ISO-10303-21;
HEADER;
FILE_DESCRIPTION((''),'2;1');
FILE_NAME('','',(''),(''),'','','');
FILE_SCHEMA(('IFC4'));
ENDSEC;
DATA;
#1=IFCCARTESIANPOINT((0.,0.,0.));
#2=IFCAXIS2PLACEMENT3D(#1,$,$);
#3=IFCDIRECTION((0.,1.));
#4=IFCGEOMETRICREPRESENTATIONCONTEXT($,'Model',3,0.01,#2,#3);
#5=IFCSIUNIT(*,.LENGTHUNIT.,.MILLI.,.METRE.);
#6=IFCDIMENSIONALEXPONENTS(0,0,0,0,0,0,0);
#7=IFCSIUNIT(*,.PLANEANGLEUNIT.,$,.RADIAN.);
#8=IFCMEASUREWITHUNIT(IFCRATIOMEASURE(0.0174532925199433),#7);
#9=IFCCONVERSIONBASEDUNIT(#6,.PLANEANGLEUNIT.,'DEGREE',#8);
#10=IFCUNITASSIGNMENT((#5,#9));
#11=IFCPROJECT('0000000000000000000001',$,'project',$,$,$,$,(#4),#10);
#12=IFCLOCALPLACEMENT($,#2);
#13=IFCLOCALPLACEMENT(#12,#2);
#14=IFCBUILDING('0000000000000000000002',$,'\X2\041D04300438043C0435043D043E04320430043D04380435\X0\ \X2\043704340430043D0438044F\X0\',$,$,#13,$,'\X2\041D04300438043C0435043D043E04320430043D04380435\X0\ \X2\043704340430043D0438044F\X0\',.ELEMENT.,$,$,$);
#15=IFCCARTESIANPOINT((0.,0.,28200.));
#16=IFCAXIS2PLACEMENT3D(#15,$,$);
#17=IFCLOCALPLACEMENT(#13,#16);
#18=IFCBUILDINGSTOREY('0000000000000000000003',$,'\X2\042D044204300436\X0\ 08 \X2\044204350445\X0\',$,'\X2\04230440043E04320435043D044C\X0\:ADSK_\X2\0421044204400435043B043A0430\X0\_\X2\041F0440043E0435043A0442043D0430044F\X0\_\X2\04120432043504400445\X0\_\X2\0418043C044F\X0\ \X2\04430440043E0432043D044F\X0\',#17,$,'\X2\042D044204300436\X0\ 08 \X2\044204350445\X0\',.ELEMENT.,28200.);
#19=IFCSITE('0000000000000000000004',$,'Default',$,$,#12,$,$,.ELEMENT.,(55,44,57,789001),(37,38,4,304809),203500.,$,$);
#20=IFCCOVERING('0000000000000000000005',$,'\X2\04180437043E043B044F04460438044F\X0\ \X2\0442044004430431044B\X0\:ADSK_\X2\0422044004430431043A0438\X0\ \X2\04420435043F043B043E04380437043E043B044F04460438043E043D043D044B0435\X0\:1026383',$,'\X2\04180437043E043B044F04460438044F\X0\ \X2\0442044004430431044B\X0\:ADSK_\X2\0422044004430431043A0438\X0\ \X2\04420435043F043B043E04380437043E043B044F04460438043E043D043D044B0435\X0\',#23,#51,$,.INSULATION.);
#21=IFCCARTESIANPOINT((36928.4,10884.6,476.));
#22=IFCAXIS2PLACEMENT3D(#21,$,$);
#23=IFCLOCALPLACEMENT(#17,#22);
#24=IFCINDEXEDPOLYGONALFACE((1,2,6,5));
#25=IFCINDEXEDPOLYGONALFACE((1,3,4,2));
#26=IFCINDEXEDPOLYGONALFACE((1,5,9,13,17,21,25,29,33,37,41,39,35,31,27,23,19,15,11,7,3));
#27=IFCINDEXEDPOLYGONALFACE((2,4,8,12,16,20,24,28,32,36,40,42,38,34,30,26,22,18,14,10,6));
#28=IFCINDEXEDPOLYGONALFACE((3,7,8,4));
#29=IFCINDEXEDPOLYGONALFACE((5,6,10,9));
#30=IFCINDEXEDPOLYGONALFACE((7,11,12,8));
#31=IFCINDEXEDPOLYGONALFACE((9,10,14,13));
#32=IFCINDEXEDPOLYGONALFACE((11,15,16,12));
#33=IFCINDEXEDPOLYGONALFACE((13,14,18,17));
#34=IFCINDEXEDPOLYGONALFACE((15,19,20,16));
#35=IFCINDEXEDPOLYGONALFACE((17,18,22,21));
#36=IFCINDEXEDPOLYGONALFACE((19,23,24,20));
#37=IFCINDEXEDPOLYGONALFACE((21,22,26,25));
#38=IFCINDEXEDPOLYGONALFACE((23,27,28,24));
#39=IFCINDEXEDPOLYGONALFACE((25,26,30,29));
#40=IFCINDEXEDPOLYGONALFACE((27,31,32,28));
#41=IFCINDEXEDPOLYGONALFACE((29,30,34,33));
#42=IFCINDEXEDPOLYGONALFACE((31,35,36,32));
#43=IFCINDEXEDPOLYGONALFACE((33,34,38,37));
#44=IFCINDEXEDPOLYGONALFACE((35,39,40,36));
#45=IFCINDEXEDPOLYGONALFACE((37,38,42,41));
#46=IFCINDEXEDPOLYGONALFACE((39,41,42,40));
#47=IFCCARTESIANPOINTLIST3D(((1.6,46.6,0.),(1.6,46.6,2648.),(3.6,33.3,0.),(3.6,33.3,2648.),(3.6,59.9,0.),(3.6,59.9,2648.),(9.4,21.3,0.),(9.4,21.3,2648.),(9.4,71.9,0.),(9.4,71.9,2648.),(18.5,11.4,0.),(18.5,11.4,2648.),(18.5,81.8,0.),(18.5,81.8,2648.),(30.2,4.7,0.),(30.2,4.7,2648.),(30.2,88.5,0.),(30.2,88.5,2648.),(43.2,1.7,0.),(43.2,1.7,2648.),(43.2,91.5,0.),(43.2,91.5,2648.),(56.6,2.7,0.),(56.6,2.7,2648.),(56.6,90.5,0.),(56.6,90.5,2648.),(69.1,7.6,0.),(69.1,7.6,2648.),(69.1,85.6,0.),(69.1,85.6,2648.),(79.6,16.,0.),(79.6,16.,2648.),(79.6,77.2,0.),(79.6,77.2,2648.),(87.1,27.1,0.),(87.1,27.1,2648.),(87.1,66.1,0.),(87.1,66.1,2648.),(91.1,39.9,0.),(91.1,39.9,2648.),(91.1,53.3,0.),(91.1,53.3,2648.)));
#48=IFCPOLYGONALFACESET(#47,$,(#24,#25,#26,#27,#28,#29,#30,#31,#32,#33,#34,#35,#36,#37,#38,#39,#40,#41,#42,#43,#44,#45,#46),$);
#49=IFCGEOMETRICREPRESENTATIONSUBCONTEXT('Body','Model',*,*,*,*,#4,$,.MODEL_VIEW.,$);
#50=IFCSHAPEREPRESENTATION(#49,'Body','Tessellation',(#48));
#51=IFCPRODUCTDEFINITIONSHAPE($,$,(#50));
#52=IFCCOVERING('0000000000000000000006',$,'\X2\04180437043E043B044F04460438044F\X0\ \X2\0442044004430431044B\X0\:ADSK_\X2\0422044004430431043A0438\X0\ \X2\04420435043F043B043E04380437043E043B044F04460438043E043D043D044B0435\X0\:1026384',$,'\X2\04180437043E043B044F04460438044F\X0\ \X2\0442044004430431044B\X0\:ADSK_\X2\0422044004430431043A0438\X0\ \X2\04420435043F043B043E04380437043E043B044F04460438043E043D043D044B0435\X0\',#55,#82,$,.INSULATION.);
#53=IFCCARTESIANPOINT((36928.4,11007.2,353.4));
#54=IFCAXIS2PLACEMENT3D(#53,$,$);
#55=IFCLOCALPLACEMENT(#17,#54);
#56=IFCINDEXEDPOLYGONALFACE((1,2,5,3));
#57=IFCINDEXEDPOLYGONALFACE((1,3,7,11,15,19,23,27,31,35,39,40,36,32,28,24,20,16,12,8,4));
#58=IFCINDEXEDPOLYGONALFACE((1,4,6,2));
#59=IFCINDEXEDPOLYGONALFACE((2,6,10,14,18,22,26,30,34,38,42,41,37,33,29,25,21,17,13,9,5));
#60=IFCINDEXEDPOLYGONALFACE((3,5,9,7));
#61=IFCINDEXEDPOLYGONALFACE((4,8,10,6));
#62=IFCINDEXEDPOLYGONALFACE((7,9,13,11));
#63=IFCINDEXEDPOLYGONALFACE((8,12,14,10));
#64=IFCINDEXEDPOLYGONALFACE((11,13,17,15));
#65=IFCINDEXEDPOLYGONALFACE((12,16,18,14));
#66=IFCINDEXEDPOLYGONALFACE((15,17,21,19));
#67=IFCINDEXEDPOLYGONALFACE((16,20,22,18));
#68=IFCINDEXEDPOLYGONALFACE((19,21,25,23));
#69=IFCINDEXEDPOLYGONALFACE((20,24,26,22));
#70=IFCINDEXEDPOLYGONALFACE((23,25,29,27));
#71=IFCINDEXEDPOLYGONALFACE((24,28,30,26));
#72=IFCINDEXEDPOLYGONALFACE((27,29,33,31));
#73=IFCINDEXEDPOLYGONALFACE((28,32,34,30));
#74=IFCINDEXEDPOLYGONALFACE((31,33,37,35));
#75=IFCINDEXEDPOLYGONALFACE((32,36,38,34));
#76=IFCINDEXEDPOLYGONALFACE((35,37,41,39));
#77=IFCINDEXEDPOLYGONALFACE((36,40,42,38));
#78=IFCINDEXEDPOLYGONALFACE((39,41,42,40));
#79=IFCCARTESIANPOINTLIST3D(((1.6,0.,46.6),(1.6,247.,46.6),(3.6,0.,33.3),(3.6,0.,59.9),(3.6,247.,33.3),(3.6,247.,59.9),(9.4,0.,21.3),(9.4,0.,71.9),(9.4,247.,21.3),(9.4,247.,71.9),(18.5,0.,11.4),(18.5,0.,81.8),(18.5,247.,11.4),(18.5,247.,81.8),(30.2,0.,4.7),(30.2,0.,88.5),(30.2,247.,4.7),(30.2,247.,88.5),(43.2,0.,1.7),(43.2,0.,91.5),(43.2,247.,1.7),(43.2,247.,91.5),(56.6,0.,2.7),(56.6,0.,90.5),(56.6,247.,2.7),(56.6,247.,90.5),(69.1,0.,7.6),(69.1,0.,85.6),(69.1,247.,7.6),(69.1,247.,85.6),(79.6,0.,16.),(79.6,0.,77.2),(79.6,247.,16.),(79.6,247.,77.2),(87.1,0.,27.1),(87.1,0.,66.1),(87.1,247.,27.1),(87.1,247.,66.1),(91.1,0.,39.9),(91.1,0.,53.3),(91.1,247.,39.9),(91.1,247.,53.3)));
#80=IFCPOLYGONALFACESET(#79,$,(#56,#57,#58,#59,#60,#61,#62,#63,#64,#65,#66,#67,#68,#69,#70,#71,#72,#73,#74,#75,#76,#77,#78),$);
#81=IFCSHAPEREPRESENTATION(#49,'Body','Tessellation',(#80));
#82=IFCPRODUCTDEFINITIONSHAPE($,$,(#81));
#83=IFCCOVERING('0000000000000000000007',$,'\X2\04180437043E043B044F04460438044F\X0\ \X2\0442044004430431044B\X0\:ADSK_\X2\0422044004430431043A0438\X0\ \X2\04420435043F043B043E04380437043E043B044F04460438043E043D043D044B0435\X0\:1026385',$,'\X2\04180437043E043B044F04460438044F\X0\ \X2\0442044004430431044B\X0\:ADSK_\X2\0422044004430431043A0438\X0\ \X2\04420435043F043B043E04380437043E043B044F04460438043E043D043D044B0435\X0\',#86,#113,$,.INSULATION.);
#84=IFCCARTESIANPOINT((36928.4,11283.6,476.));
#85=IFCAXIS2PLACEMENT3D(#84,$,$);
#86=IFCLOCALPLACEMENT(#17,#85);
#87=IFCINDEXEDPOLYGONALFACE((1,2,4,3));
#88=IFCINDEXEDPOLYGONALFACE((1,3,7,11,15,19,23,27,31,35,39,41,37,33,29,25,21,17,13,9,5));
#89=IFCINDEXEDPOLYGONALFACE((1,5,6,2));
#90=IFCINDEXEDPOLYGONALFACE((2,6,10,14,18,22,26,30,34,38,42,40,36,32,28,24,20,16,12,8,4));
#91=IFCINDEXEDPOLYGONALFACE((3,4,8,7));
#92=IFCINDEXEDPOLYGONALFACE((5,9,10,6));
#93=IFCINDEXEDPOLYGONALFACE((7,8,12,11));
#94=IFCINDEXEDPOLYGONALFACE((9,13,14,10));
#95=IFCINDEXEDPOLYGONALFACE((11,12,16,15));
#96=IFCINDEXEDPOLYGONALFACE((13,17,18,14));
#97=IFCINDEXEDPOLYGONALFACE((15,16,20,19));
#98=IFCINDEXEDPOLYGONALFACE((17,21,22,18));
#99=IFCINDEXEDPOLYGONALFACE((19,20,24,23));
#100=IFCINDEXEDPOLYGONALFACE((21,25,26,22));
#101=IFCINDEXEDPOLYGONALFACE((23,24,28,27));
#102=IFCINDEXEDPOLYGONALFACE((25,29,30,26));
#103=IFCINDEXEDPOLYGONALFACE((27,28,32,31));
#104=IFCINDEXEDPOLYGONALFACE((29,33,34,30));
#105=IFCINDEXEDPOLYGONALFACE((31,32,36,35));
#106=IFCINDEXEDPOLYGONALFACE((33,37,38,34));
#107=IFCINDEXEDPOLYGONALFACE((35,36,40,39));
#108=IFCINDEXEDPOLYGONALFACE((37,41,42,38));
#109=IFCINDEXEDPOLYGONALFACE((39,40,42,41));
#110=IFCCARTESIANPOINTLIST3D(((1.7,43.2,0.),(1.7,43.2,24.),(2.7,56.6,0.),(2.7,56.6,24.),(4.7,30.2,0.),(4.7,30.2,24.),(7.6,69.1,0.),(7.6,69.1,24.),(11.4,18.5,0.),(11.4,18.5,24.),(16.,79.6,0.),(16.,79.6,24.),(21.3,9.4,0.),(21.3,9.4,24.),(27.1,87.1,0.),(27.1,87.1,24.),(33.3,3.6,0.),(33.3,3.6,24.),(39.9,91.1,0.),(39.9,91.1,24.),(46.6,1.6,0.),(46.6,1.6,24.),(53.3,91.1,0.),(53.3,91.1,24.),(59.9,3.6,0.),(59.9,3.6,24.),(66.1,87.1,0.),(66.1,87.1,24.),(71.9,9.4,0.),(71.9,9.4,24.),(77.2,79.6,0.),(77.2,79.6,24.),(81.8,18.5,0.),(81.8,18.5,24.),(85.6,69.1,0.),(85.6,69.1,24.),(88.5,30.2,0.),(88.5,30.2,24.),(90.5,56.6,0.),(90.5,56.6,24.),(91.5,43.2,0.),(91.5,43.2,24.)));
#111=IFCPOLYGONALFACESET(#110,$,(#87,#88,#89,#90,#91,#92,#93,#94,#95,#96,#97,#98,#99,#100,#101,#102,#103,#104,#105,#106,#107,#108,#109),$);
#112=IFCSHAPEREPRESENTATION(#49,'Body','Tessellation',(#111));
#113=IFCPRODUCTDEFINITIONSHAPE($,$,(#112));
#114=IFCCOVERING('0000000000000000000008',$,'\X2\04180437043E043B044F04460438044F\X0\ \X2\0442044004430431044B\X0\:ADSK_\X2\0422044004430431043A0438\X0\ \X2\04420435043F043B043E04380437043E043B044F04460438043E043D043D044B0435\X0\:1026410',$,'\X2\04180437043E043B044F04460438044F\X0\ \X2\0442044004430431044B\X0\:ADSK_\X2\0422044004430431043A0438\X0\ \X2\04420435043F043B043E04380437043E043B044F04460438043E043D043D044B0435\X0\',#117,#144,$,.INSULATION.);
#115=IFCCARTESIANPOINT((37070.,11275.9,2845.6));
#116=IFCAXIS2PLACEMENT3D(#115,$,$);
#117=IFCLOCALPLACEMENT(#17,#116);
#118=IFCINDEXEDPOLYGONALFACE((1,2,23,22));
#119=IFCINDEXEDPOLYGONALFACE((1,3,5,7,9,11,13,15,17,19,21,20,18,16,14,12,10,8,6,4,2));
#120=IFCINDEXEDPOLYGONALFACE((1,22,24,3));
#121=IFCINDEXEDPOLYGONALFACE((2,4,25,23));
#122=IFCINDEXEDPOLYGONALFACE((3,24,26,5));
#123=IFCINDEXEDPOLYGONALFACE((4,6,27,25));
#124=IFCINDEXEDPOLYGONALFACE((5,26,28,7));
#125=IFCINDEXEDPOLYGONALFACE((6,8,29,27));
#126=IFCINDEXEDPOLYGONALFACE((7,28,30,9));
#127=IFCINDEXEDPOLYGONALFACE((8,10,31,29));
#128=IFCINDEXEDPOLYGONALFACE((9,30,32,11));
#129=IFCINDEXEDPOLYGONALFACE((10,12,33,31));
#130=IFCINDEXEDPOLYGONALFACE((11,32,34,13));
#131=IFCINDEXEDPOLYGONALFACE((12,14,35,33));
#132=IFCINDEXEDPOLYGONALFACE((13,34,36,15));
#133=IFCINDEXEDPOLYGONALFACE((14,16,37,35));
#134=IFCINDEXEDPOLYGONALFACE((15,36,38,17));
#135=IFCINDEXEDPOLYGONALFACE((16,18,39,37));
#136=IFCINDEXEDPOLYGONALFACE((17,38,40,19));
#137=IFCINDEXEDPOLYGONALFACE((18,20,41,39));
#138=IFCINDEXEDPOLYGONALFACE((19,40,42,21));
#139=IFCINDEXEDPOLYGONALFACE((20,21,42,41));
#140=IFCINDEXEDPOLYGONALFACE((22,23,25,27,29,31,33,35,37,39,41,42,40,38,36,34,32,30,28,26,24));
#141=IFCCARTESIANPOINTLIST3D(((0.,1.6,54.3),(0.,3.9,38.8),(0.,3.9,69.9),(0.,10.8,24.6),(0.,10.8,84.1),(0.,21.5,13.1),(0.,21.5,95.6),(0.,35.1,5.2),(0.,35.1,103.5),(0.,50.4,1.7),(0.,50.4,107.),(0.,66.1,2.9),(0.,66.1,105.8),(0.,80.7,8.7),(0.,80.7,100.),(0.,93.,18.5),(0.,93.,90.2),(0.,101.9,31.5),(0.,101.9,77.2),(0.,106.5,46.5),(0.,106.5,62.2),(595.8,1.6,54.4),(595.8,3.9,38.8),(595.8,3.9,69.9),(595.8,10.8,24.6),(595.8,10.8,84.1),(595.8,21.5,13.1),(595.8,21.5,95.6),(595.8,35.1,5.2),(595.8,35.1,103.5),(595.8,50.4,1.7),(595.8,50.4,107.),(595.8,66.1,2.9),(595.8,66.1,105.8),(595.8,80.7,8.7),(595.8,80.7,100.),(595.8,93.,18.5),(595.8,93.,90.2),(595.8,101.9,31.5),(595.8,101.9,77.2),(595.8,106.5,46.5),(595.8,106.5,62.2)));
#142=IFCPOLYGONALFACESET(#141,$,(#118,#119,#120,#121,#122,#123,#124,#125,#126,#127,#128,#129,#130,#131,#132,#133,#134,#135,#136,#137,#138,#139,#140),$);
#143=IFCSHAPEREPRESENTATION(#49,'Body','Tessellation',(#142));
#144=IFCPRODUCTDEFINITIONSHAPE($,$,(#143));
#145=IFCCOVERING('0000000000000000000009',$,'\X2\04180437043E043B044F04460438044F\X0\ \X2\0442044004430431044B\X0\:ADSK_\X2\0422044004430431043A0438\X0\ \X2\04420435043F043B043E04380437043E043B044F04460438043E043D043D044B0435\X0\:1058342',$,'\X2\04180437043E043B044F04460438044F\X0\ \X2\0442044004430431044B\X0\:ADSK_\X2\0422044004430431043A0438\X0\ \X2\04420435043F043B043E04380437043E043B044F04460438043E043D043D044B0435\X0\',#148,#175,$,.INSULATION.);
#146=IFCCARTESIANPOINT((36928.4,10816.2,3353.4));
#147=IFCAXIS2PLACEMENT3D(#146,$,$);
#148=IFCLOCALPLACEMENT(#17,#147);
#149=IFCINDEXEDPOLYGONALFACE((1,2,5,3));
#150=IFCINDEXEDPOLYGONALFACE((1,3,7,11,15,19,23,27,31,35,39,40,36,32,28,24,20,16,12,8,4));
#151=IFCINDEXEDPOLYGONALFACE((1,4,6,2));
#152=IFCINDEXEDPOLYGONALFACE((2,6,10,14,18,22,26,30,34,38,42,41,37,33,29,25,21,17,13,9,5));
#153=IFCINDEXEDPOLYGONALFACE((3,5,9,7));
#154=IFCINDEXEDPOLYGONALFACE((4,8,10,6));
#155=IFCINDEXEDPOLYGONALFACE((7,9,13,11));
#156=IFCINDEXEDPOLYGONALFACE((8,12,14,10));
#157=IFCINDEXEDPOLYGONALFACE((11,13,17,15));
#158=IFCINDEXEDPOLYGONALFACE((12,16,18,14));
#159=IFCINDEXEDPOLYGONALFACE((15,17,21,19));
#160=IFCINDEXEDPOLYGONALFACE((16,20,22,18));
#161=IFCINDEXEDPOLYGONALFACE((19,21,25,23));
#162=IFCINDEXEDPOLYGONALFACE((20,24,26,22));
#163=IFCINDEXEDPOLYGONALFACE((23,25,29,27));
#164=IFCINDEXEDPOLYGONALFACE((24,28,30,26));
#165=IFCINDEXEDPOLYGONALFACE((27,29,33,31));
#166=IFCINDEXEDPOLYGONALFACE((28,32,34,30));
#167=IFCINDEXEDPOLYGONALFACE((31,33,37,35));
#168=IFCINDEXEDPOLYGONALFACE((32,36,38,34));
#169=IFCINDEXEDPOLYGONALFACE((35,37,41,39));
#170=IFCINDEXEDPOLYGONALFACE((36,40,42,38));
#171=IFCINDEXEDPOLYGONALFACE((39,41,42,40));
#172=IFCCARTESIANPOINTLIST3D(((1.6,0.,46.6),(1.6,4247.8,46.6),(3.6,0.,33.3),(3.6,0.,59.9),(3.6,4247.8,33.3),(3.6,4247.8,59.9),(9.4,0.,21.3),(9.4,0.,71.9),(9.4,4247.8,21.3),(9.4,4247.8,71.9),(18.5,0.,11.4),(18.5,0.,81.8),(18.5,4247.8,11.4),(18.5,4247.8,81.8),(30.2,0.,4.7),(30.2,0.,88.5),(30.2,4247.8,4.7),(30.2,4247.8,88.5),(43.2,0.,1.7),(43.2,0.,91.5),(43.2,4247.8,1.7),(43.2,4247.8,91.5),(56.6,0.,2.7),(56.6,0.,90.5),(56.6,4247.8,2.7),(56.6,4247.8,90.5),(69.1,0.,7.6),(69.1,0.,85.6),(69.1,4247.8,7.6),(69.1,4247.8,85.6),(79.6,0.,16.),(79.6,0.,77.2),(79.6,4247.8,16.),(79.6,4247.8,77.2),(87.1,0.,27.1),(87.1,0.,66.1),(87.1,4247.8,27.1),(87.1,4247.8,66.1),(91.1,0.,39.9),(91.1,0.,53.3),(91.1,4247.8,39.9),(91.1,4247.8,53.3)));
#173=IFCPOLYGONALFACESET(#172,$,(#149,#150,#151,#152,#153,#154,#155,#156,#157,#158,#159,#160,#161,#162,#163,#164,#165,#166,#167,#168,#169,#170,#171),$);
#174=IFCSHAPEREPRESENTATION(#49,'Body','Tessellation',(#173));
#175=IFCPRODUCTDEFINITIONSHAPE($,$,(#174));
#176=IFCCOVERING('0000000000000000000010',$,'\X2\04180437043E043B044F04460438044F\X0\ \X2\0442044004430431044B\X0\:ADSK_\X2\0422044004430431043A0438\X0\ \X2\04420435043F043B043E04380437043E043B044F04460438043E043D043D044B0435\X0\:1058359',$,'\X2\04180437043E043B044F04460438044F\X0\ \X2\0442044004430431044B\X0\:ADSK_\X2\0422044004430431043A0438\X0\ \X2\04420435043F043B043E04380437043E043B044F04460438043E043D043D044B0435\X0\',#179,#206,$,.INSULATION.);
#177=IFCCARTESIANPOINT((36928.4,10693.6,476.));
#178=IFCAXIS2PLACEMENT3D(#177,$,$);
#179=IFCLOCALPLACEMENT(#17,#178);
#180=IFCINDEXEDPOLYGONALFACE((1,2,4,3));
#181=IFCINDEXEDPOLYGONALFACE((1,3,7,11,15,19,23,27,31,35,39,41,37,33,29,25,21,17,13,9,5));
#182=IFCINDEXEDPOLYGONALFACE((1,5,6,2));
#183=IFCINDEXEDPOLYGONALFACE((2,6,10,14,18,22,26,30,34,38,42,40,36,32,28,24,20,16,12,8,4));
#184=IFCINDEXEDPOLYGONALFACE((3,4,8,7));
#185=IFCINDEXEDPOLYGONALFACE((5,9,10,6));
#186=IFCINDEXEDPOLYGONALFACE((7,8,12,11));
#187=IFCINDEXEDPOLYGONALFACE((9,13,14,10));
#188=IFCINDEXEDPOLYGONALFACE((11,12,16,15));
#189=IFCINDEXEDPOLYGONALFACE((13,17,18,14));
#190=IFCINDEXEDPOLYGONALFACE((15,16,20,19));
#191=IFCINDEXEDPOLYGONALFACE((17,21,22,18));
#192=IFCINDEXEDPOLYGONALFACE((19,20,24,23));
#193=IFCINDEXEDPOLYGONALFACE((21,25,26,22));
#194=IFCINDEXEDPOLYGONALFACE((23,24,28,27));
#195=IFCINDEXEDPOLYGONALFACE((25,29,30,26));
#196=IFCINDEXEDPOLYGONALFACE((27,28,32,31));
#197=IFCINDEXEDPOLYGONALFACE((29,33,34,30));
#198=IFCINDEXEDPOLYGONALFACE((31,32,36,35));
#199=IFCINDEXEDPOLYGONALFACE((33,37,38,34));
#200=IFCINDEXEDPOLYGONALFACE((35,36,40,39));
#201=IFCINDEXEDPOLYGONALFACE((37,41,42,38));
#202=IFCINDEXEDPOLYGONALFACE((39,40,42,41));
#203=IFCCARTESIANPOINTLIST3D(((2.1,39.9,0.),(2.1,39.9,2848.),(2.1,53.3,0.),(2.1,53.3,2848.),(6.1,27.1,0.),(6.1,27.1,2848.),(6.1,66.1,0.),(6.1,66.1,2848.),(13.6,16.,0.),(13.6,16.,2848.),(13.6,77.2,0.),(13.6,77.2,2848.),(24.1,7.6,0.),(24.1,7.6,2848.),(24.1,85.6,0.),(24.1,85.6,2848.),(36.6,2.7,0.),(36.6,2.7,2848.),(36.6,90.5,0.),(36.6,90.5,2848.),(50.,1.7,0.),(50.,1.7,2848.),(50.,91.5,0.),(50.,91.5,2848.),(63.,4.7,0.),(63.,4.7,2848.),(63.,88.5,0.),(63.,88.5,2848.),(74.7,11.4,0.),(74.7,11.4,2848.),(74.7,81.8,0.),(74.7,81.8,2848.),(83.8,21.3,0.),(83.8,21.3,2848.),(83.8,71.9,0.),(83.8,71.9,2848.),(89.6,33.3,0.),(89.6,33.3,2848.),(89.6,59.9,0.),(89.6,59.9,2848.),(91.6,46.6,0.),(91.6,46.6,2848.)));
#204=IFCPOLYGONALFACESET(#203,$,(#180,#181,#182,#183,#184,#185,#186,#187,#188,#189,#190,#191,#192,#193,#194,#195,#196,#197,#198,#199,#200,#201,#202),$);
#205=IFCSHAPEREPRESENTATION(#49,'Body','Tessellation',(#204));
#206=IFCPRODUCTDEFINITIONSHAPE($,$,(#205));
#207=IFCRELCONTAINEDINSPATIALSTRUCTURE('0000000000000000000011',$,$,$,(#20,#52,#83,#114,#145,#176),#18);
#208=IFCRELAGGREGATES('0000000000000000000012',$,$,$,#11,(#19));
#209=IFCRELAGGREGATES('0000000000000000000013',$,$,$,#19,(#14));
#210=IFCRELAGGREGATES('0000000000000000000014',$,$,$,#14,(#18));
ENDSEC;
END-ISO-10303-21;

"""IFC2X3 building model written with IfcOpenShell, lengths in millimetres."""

from ifc_helpers import new_model, entity, si_unit, converted_unit, direction, frame, origin, origin_2d_with_axis, place, context, subcontext, project, spatial, circle, extrude, element, save


model = new_model("IFC2X3")

# Units and contexts
model_context = context("Model", 3, precision=0.01, world=origin(), true_north=direction((0.0, 1.0)))
body_context = subcontext(model_context, "Body", "Model", "MODEL_VIEW")
ifc_project = project(units=[si_unit("LENGTHUNIT", "METRE", prefix="MILLI"), converted_unit("PLANEANGLEUNIT", "DEGREE", entity("IfcRatioMeasure", 0.0174532925199433), si_unit("PLANEANGLEUNIT", "RADIAN"), dimensions=[0, 0, 0, 0, 0, 0, 0])], contexts=[model_context])

# Site, building, storey
site_placement = place(None, origin())
site = spatial("IfcSite", under=ifc_project, at=site_placement, Name="Default", CompositionType="ELEMENT", RefLatitude=(55, 44, 57, 789001), RefLongitude=(37, 38, 4, 304809), RefElevation=203500.0)
building_placement = place(site_placement, origin())
building = spatial("IfcBuilding", under=site, at=building_placement, Name="Наименование здания", LongName="Наименование здания", CompositionType="ELEMENT")
storey_placement = place(building_placement, frame((0.0, 0.0, 28200.0)))
storey = spatial("IfcBuildingStorey", under=building, at=storey_placement, Name="Этаж 08 тех", ObjectType="Уровень:ADSK_Стрелка_Проектная_Вверх_Имя уровня", LongName="Этаж 08 тех", CompositionType="ELEMENT", Elevation=28200.0)

# Coverings
covering_1_placement = place(storey_placement, frame((36928.4, 10884.6, 476.0)))
element("IfcCovering", 1, at=covering_1_placement, inside=storey, Name="Изоляция трубы:ADSK_Трубки теплоизоляционные:1026383", ObjectType="Изоляция трубы:ADSK_Трубки теплоизоляционные", PredefinedType="INSULATION", context=body_context, shape_type="SweptSolid", body=[
    extrude(circle(Radius=45.0, at=origin_2d_with_axis()), frame((46.6, 46.6, 0.0), z_axis=(0.0, 0.0, 1.0), x_axis=(-1.0, 0.0, 0.0)), (0.0, 0.0, 1.0), 2648.0),
])
covering_2_placement = place(storey_placement, frame((36928.4, 11007.2, 353.4)))
element("IfcCovering", 2, at=covering_2_placement, inside=storey, Name="Изоляция трубы:ADSK_Трубки теплоизоляционные:1026384", ObjectType="Изоляция трубы:ADSK_Трубки теплоизоляционные", PredefinedType="INSULATION", context=body_context, shape_type="SweptSolid", body=[
    extrude(circle(Radius=45.0, at=origin_2d_with_axis()), frame((46.6, 0.0, 46.6), z_axis=(0.0, 1.0, 0.0), x_axis=(-1.0, 0.0, 0.0)), (0.0, 0.0, 1.0), 247.0),
])
covering_3_placement = place(storey_placement, frame((36928.4, 11283.6, 476.0)))
element("IfcCovering", 3, at=covering_3_placement, inside=storey, Name="Изоляция трубы:ADSK_Трубки теплоизоляционные:1026385", ObjectType="Изоляция трубы:ADSK_Трубки теплоизоляционные", PredefinedType="INSULATION", context=body_context, shape_type="SweptSolid", body=[
    extrude(circle(Radius=45.0, at=origin_2d_with_axis()), frame((46.6, 46.6, 0.0), z_axis=(0.0, 0.0, 1.0), x_axis=(0.0, -1.0, 0.0)), (0.0, 0.0, 1.0), 24.0),
])
covering_4_placement = place(storey_placement, frame((37070.0, 11275.9, 2845.6)))
element("IfcCovering", 4, at=covering_4_placement, inside=storey, Name="Изоляция трубы:ADSK_Трубки теплоизоляционные:1026410", ObjectType="Изоляция трубы:ADSK_Трубки теплоизоляционные", PredefinedType="INSULATION", context=body_context, shape_type="SweptSolid", body=[
    extrude(circle(Radius=52.8, at=origin_2d_with_axis()), frame((0.0, 54.4, 54.4), z_axis=(1.0, 0.0, 0.000003), x_axis=(0.0, -1.0, 0.0)), (0.0, 0.0, 1.0), 595.8),
])
covering_5_placement = place(storey_placement, frame((36928.4, 10816.2, 3353.4)))
element("IfcCovering", 5, at=covering_5_placement, inside=storey, Name="Изоляция трубы:ADSK_Трубки теплоизоляционные:1058342", ObjectType="Изоляция трубы:ADSK_Трубки теплоизоляционные", PredefinedType="INSULATION", context=body_context, shape_type="SweptSolid", body=[
    extrude(circle(Radius=45.0, at=origin_2d_with_axis()), frame((46.6, 0.0, 46.6), z_axis=(0.0, 1.0, 0.0), x_axis=(-1.0, 0.0, 0.0)), (0.0, 0.0, 1.0), 4247.8),
])
covering_6_placement = place(storey_placement, frame((36928.4, 10693.6, 476.0)))
element("IfcCovering", 6, at=covering_6_placement, inside=storey, Name="Изоляция трубы:ADSK_Трубки теплоизоляционные:1058359", ObjectType="Изоляция трубы:ADSK_Трубки теплоизоляционные", PredefinedType="INSULATION", context=body_context, shape_type="SweptSolid", body=[
    extrude(circle(Radius=45.0, at=origin_2d_with_axis()), frame((46.6, 46.6, 0.0)), (0.0, 0.0, 1.0), 2848.0),
])

save(model, "model.ifc")
